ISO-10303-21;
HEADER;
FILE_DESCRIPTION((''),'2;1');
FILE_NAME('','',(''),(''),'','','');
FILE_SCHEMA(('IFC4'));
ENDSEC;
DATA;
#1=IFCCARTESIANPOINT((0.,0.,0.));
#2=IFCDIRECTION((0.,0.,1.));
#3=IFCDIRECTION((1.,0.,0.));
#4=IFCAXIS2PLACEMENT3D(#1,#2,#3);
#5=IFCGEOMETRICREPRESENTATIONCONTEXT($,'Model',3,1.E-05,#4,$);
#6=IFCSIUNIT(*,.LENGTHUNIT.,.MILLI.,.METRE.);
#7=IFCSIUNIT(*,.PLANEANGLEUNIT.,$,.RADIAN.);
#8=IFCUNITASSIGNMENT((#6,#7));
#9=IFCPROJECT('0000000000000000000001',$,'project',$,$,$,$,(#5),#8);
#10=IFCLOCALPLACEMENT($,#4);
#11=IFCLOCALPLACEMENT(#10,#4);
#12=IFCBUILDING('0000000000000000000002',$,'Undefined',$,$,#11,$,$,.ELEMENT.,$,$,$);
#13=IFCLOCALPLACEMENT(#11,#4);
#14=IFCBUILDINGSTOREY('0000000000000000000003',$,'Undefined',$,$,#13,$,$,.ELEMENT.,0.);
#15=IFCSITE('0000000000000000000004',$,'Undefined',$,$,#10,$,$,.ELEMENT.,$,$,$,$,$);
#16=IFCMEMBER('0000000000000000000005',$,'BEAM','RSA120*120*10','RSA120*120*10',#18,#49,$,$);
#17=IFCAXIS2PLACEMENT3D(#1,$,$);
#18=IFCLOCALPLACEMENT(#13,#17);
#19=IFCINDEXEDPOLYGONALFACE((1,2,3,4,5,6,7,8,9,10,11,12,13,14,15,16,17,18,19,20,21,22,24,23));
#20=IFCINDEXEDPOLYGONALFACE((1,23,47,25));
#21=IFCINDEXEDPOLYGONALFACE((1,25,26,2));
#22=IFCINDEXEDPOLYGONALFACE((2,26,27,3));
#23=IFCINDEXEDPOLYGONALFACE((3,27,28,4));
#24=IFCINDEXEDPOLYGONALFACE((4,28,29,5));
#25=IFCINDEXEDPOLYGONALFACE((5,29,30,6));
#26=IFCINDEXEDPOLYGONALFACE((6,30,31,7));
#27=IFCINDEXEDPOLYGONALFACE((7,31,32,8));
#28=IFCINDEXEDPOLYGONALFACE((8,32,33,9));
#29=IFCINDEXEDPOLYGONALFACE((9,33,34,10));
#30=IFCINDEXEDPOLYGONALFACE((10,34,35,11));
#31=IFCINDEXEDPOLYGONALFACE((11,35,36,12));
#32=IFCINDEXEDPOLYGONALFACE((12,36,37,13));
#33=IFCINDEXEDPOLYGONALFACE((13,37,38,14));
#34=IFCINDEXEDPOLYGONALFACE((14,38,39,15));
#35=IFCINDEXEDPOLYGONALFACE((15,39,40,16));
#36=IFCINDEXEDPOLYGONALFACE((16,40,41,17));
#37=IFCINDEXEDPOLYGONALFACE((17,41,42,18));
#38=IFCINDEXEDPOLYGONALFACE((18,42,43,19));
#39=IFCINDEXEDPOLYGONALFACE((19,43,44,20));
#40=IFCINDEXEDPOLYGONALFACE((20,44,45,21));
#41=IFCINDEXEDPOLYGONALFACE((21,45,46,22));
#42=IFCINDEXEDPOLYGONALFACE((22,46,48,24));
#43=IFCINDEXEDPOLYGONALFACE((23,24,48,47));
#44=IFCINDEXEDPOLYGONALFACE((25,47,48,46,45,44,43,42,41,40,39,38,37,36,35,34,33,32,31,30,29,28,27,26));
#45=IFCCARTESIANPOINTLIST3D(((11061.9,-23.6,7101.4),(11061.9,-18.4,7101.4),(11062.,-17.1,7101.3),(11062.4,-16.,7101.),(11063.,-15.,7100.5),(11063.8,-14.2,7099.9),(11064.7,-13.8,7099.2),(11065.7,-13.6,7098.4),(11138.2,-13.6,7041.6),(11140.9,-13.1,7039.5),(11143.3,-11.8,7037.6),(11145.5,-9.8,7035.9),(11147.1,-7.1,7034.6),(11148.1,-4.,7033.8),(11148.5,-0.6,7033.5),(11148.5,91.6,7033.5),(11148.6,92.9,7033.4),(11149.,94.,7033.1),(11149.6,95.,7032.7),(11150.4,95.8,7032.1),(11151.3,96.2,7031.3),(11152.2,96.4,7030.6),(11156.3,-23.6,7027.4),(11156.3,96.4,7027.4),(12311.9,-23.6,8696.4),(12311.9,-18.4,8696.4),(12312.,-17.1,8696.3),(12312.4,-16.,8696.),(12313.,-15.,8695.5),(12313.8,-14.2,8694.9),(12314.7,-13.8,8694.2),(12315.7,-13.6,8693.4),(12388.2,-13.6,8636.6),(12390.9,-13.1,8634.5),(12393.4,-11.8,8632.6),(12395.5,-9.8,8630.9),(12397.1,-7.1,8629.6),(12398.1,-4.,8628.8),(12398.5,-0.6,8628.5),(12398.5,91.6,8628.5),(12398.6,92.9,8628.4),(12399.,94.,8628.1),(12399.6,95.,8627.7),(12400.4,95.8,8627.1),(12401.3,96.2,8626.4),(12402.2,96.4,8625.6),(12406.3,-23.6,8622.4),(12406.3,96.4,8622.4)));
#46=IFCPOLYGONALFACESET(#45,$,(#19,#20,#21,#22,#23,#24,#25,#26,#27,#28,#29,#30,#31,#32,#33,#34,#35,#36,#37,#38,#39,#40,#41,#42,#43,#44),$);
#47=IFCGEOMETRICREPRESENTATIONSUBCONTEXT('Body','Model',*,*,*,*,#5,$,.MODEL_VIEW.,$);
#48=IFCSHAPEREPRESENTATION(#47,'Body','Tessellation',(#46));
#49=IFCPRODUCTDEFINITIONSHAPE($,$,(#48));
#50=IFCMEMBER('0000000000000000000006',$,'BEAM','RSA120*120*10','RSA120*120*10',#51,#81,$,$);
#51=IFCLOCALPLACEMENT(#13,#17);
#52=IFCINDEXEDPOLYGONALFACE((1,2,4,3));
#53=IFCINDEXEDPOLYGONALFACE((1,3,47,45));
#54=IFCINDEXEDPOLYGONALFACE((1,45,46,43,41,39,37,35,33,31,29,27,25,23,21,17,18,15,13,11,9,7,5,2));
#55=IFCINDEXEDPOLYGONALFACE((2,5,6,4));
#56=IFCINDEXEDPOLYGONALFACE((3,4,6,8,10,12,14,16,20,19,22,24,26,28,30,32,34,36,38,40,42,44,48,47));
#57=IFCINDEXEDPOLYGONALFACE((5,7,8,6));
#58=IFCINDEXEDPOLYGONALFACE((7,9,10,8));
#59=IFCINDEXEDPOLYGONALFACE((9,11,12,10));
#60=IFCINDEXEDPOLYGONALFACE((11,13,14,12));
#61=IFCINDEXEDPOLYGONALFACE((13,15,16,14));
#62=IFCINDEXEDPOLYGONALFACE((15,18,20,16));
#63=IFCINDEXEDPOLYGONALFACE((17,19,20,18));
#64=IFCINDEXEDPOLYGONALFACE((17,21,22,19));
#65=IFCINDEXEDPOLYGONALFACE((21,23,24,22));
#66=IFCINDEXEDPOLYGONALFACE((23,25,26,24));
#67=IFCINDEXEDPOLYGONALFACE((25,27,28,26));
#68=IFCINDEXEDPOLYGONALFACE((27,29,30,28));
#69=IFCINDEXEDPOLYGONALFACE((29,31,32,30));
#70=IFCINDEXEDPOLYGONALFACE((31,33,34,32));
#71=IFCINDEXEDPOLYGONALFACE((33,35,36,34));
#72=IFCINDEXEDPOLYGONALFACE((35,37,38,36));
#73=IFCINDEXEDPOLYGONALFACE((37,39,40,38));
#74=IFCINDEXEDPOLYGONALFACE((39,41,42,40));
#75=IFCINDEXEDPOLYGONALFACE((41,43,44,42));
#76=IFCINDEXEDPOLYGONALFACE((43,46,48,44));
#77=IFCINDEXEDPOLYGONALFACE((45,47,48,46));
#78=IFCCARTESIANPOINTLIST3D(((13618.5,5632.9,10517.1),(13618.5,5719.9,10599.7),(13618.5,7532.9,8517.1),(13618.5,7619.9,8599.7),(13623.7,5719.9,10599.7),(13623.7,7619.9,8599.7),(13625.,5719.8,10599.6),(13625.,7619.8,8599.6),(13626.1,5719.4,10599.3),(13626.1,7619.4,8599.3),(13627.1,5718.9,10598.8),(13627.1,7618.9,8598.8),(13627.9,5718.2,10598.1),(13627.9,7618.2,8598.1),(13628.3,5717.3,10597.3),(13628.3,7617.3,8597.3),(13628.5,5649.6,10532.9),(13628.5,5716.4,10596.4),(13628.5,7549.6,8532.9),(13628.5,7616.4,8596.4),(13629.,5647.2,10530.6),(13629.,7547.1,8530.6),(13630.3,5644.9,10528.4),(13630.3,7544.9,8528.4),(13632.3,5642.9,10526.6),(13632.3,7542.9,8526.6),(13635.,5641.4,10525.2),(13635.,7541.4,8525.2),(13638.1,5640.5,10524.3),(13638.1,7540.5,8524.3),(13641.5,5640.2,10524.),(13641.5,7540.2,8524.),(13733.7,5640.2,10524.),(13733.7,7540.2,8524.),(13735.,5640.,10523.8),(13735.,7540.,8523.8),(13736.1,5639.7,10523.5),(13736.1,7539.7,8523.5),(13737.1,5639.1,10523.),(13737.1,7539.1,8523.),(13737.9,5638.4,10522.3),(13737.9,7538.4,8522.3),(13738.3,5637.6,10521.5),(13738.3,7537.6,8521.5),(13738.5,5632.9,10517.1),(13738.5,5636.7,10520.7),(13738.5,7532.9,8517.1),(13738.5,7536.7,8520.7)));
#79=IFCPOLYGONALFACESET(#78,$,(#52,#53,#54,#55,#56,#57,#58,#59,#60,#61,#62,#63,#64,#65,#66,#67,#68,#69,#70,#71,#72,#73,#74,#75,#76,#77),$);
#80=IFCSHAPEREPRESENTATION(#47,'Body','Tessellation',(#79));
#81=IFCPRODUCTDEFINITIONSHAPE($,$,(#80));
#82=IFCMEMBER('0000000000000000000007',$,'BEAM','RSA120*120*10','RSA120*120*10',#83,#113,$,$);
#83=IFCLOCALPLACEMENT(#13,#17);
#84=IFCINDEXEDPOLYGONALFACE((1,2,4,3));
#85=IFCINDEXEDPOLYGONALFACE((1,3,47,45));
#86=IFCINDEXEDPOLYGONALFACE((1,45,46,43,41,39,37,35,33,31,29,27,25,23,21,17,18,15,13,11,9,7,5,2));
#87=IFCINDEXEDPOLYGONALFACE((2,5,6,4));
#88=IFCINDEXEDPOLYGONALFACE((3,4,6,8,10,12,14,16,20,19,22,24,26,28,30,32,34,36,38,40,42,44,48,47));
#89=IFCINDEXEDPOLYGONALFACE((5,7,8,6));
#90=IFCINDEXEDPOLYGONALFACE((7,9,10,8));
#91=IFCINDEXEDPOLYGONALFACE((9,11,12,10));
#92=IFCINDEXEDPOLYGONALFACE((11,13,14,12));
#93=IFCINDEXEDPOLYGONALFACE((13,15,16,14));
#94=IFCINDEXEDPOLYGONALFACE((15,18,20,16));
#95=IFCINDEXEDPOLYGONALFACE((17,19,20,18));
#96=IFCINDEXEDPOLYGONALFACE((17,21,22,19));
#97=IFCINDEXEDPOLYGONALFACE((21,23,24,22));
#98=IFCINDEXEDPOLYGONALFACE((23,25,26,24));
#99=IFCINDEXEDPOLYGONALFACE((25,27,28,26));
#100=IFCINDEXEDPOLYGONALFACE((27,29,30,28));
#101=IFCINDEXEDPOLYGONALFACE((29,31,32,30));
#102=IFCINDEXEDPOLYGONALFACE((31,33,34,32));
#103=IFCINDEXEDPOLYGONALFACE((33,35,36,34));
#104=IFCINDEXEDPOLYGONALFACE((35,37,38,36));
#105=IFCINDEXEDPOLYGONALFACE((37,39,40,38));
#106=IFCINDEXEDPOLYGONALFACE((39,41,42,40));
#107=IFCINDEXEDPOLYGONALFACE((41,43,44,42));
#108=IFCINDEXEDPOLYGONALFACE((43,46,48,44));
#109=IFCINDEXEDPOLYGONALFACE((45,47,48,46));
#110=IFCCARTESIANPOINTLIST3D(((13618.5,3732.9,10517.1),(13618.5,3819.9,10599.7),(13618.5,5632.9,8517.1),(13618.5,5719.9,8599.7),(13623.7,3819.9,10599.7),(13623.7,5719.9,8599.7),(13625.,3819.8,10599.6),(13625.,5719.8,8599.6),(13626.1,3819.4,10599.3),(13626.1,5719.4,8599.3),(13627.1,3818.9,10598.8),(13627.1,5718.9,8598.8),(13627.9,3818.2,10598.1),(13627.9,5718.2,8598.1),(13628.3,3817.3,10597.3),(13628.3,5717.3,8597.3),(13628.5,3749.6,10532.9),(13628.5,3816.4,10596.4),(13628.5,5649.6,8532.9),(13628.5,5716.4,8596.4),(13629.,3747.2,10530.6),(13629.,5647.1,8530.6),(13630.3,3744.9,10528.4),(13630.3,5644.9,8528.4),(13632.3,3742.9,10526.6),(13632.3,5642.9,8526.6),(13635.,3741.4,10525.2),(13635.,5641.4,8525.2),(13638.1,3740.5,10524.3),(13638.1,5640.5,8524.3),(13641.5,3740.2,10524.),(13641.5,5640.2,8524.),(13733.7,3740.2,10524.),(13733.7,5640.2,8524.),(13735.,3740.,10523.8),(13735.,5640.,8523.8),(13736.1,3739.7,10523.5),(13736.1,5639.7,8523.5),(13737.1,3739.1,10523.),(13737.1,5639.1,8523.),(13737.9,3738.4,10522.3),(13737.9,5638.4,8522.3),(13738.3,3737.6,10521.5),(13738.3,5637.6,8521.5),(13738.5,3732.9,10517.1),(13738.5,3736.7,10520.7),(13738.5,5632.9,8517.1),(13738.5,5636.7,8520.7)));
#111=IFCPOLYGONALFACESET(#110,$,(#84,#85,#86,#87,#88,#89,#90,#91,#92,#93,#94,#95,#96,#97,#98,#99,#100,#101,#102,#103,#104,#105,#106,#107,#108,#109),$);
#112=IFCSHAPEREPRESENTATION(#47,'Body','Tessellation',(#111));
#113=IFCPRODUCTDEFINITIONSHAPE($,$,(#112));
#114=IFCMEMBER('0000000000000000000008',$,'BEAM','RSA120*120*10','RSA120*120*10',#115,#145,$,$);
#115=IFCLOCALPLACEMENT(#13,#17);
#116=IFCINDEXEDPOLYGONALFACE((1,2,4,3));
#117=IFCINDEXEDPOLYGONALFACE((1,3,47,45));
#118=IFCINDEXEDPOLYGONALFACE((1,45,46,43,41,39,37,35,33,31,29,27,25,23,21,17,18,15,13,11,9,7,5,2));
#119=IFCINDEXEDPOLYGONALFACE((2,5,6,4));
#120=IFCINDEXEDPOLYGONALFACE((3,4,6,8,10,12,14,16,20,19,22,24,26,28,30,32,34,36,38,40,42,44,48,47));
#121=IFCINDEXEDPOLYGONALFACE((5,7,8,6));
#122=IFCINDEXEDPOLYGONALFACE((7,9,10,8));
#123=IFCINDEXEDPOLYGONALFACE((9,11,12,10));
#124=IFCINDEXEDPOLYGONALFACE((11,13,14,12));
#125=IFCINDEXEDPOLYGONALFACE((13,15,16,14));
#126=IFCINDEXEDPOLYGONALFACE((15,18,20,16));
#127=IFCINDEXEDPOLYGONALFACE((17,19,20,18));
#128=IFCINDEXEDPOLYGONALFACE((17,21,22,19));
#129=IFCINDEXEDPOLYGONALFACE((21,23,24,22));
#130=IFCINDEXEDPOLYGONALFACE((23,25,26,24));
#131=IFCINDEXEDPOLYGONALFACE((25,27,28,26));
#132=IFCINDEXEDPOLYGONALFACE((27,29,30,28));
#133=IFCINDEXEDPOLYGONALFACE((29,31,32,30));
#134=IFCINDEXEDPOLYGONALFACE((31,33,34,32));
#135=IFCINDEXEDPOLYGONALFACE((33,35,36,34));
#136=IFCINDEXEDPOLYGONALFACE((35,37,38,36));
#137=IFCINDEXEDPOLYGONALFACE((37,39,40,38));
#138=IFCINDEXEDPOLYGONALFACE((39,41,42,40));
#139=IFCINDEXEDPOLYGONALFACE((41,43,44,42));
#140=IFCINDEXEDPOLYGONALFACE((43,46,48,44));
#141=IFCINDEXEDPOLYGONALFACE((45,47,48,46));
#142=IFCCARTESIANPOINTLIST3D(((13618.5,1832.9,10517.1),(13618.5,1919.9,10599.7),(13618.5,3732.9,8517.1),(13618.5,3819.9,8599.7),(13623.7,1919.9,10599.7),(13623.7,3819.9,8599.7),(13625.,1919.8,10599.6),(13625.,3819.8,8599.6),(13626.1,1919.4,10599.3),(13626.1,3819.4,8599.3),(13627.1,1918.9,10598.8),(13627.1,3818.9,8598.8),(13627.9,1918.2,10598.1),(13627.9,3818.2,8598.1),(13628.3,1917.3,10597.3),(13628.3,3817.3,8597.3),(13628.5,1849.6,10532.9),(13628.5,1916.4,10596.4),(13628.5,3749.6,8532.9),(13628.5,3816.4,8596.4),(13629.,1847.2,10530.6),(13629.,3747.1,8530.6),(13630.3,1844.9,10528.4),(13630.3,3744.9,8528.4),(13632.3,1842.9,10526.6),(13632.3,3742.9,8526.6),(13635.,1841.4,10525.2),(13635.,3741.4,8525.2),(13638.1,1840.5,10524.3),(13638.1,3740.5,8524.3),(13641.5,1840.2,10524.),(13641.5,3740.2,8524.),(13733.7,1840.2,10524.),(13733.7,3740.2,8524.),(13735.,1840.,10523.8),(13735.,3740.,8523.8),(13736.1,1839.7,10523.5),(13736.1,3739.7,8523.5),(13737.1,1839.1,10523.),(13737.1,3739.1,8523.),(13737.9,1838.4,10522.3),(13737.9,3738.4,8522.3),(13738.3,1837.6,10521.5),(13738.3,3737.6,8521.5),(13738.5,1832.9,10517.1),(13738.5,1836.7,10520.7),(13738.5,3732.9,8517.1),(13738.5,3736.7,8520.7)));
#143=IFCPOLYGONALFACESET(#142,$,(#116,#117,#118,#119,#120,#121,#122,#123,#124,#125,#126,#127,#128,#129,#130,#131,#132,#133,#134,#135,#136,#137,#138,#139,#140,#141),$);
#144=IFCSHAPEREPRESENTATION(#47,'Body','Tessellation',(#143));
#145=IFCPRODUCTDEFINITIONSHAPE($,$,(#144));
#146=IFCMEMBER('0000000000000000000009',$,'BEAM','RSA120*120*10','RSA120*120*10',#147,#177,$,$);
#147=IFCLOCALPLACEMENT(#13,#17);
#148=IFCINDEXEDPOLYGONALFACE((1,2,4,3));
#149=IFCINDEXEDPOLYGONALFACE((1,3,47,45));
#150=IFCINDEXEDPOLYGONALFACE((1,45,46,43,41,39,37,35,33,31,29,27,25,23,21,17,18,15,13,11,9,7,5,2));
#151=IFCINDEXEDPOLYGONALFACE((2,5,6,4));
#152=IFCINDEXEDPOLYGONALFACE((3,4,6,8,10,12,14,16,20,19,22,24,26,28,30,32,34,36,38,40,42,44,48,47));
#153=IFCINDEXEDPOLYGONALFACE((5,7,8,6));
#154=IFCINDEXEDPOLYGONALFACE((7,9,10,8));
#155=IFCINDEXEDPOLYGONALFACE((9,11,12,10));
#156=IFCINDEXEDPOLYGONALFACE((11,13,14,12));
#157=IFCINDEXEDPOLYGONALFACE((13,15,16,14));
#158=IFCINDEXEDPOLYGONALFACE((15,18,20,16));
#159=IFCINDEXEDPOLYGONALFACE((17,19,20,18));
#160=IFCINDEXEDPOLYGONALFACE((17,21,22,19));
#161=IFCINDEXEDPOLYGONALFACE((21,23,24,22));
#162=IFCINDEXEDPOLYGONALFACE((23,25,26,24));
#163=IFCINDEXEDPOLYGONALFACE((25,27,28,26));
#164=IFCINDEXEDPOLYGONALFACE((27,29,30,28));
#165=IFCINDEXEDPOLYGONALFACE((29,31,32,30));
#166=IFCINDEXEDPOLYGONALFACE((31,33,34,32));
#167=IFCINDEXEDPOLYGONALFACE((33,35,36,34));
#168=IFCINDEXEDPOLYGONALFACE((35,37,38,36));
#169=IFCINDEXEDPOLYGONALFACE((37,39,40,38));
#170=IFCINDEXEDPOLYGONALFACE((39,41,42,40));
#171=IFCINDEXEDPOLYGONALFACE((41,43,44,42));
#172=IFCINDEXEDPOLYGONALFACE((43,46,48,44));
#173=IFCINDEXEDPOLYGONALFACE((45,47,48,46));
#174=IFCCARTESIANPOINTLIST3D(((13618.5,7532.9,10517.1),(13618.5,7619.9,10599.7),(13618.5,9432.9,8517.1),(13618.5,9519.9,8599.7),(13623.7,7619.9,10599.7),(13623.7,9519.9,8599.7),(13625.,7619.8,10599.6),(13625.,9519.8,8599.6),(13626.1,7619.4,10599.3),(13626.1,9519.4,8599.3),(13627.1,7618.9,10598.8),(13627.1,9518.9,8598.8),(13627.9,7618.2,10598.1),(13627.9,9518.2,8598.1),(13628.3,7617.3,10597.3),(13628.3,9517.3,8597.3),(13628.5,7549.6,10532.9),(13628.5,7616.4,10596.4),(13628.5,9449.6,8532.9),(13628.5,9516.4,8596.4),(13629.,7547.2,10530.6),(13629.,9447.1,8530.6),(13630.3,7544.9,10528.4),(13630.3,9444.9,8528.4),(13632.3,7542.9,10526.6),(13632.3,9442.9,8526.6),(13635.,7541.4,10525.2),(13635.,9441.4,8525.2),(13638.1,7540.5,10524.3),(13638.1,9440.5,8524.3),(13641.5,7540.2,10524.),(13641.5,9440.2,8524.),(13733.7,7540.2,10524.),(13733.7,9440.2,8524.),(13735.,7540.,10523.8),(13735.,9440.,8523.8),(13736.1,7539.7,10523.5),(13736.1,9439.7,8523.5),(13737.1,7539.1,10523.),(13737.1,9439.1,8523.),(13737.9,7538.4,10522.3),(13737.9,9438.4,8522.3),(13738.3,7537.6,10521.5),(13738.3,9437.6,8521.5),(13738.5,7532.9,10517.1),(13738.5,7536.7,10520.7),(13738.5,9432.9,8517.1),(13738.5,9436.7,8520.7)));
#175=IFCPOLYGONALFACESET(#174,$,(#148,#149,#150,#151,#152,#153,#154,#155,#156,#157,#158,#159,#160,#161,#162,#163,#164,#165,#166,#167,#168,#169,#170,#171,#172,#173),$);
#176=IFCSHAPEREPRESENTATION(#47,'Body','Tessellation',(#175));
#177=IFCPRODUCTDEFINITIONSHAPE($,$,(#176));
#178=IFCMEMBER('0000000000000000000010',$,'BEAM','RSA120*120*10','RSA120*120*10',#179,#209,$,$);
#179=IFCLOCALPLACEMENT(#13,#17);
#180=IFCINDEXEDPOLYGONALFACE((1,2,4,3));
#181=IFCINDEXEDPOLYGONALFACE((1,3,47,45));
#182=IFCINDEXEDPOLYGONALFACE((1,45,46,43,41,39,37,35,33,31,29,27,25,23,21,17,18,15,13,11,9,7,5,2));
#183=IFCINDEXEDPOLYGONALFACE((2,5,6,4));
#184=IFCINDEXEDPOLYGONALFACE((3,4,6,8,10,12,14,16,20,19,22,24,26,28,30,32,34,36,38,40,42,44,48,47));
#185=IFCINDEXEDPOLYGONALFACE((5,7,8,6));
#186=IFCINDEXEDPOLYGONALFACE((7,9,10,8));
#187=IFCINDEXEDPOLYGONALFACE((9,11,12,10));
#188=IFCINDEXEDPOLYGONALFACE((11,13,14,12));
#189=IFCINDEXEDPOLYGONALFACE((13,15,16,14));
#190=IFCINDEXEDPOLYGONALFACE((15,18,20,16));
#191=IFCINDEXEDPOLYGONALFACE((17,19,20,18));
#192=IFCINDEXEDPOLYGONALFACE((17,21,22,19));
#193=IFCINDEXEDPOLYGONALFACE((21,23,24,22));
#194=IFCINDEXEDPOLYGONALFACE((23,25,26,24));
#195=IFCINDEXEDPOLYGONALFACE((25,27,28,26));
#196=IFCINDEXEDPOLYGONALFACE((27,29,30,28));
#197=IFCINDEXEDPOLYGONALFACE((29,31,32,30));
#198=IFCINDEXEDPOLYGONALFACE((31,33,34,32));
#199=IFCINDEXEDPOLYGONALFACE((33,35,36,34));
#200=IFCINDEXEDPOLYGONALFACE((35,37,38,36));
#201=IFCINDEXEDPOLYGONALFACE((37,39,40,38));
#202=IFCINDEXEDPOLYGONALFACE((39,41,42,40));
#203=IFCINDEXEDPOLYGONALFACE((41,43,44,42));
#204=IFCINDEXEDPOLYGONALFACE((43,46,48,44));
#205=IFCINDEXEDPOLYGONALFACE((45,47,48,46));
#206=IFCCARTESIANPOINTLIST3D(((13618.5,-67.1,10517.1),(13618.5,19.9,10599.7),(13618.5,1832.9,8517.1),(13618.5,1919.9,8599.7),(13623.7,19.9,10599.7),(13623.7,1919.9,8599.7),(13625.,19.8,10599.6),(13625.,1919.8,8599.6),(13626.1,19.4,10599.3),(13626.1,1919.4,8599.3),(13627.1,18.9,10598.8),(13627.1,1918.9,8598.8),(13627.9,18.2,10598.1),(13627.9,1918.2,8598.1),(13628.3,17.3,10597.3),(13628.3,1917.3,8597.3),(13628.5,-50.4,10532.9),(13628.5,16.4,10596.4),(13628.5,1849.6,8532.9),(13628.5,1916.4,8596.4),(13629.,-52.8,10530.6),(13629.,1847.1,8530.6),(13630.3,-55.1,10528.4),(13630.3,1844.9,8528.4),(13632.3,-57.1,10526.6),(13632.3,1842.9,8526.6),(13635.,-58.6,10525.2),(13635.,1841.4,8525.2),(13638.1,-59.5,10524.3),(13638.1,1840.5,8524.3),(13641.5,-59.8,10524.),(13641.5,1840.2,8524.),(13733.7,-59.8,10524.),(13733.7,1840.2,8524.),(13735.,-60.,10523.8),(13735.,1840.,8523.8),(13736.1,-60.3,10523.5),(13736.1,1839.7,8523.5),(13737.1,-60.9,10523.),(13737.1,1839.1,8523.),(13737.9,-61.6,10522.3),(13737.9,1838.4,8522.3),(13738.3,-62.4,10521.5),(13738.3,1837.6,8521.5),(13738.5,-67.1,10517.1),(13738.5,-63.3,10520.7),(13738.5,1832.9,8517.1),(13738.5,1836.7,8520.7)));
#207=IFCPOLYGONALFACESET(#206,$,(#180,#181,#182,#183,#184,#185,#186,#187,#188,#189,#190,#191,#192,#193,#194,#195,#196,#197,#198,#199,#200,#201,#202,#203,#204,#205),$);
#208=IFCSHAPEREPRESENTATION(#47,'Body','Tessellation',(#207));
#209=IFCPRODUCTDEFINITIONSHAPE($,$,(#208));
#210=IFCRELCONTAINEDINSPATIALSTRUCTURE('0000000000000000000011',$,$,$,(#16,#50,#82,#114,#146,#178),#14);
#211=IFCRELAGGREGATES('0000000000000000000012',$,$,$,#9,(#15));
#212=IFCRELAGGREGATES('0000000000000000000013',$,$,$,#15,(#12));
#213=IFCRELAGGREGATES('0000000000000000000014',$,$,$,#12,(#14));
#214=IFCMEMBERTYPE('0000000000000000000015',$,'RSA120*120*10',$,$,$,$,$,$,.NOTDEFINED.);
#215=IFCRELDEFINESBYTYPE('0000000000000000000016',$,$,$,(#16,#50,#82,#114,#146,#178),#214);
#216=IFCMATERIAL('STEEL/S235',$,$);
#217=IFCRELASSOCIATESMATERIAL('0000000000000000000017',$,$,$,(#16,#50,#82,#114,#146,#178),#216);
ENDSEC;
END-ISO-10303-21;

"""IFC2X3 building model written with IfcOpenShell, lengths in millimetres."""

from ifc_helpers import new_model, si_unit, frame, origin_with_axes, origin_2d_with_axis, place, context, subcontext, project, spatial, l_section, extrude, material, type_object, element, save


model = new_model("IFC2X3")

# Units and contexts
model_context = context("Model", 3, precision=1e-05, world=origin_with_axes())
body_context = subcontext(model_context, "Body", "Model", "MODEL_VIEW")
ifc_project = project(units=[si_unit("LENGTHUNIT", "METRE", prefix="MILLI"), si_unit("PLANEANGLEUNIT", "RADIAN")], contexts=[model_context])

# Site, building, storey
site_placement = place(None, origin_with_axes())
site = spatial("IfcSite", under=ifc_project, at=site_placement, Name="Undefined", CompositionType="ELEMENT")
building_placement = place(site_placement, origin_with_axes())
building = spatial("IfcBuilding", under=site, at=building_placement, Name="Undefined", CompositionType="ELEMENT")
storey_placement = place(building_placement, origin_with_axes())
storey = spatial("IfcBuildingStorey", under=building, at=storey_placement, Name="Undefined", CompositionType="ELEMENT", Elevation=0.0)

# Shared definitions
ifc_material = material(Name="STEEL/S235")

# Members
member_type = type_object("IfcMemberType", Name="RSA120*120*10", PredefinedType="NOTDEFINED")
member_placement = place(storey_placement, frame((12359.1, 36.4, 8659.4), z_axis=(-0.787088, 0.0, 0.616841), x_axis=(-0.616841, 0.0, -0.787088)))
element("IfcMember", 1, at=member_placement, inside=storey, type_object=member_type, material=ifc_material, Name="BEAM", Description="RSA120*120*10", ObjectType="RSA120*120*10", context=body_context, shape_type="SweptSolid", body=[
    extrude(l_section(Depth=120.0, Width=120.0, Thickness=10.0, FilletRadius=13.0, EdgeRadius=4.8, at=origin_2d_with_axis()), frame((2026.5, 0.0, 0.0), z_axis=(-1.0, 0.0, 0.0), x_axis=(0.0, -1.0, 0.0)), (0.0, 0.0, 1.0), 2026.5),
])
for number, where, z_axis, x_axis, name in (
    (2, (13678.5, 5676.4, 10558.4), (0.0, 0.724999, 0.688749), (0.0, 0.688749, -0.724999), "BEAM"),
    (3, (13678.5, 3776.4, 10558.4), (0.0, 0.724999, 0.688749), (0.0, 0.688749, -0.724999), "BEAM"),
    (4, (13678.5, 1876.4, 10558.4), (0.0, 0.724999, 0.688749), (0.0, 0.688749, -0.724999), "BEAM"),
    (5, (13678.5, 7576.4, 10558.4), (0.0, 0.724999, 0.688749), (0.0, 0.688749, -0.724999), "BEAM"),
    (6, (13678.5, -23.6, 10558.4), (0.0, 0.724999, 0.688749), (0.0, 0.688749, -0.724999), "BEAM"),
):
    element("IfcMember", number, at=place(storey_placement, frame(where, z_axis=z_axis, x_axis=x_axis)), inside=storey, type_object=member_type, material=ifc_material, Name=name, Description="RSA120*120*10", ObjectType="RSA120*120*10", context=body_context, shape_type="SweptSolid", body=[
        extrude(l_section(Depth=120.0, Width=120.0, Thickness=10.0, FilletRadius=13.0, EdgeRadius=4.8, at=origin_2d_with_axis()), frame((2758.6, 0.0, 0.0), z_axis=(-1.0, 0.0, 0.0), x_axis=(0.0, -1.0, 0.0)), (0.0, 0.0, 1.0), 2758.6),
    ])

save(model, "model.ifc")
